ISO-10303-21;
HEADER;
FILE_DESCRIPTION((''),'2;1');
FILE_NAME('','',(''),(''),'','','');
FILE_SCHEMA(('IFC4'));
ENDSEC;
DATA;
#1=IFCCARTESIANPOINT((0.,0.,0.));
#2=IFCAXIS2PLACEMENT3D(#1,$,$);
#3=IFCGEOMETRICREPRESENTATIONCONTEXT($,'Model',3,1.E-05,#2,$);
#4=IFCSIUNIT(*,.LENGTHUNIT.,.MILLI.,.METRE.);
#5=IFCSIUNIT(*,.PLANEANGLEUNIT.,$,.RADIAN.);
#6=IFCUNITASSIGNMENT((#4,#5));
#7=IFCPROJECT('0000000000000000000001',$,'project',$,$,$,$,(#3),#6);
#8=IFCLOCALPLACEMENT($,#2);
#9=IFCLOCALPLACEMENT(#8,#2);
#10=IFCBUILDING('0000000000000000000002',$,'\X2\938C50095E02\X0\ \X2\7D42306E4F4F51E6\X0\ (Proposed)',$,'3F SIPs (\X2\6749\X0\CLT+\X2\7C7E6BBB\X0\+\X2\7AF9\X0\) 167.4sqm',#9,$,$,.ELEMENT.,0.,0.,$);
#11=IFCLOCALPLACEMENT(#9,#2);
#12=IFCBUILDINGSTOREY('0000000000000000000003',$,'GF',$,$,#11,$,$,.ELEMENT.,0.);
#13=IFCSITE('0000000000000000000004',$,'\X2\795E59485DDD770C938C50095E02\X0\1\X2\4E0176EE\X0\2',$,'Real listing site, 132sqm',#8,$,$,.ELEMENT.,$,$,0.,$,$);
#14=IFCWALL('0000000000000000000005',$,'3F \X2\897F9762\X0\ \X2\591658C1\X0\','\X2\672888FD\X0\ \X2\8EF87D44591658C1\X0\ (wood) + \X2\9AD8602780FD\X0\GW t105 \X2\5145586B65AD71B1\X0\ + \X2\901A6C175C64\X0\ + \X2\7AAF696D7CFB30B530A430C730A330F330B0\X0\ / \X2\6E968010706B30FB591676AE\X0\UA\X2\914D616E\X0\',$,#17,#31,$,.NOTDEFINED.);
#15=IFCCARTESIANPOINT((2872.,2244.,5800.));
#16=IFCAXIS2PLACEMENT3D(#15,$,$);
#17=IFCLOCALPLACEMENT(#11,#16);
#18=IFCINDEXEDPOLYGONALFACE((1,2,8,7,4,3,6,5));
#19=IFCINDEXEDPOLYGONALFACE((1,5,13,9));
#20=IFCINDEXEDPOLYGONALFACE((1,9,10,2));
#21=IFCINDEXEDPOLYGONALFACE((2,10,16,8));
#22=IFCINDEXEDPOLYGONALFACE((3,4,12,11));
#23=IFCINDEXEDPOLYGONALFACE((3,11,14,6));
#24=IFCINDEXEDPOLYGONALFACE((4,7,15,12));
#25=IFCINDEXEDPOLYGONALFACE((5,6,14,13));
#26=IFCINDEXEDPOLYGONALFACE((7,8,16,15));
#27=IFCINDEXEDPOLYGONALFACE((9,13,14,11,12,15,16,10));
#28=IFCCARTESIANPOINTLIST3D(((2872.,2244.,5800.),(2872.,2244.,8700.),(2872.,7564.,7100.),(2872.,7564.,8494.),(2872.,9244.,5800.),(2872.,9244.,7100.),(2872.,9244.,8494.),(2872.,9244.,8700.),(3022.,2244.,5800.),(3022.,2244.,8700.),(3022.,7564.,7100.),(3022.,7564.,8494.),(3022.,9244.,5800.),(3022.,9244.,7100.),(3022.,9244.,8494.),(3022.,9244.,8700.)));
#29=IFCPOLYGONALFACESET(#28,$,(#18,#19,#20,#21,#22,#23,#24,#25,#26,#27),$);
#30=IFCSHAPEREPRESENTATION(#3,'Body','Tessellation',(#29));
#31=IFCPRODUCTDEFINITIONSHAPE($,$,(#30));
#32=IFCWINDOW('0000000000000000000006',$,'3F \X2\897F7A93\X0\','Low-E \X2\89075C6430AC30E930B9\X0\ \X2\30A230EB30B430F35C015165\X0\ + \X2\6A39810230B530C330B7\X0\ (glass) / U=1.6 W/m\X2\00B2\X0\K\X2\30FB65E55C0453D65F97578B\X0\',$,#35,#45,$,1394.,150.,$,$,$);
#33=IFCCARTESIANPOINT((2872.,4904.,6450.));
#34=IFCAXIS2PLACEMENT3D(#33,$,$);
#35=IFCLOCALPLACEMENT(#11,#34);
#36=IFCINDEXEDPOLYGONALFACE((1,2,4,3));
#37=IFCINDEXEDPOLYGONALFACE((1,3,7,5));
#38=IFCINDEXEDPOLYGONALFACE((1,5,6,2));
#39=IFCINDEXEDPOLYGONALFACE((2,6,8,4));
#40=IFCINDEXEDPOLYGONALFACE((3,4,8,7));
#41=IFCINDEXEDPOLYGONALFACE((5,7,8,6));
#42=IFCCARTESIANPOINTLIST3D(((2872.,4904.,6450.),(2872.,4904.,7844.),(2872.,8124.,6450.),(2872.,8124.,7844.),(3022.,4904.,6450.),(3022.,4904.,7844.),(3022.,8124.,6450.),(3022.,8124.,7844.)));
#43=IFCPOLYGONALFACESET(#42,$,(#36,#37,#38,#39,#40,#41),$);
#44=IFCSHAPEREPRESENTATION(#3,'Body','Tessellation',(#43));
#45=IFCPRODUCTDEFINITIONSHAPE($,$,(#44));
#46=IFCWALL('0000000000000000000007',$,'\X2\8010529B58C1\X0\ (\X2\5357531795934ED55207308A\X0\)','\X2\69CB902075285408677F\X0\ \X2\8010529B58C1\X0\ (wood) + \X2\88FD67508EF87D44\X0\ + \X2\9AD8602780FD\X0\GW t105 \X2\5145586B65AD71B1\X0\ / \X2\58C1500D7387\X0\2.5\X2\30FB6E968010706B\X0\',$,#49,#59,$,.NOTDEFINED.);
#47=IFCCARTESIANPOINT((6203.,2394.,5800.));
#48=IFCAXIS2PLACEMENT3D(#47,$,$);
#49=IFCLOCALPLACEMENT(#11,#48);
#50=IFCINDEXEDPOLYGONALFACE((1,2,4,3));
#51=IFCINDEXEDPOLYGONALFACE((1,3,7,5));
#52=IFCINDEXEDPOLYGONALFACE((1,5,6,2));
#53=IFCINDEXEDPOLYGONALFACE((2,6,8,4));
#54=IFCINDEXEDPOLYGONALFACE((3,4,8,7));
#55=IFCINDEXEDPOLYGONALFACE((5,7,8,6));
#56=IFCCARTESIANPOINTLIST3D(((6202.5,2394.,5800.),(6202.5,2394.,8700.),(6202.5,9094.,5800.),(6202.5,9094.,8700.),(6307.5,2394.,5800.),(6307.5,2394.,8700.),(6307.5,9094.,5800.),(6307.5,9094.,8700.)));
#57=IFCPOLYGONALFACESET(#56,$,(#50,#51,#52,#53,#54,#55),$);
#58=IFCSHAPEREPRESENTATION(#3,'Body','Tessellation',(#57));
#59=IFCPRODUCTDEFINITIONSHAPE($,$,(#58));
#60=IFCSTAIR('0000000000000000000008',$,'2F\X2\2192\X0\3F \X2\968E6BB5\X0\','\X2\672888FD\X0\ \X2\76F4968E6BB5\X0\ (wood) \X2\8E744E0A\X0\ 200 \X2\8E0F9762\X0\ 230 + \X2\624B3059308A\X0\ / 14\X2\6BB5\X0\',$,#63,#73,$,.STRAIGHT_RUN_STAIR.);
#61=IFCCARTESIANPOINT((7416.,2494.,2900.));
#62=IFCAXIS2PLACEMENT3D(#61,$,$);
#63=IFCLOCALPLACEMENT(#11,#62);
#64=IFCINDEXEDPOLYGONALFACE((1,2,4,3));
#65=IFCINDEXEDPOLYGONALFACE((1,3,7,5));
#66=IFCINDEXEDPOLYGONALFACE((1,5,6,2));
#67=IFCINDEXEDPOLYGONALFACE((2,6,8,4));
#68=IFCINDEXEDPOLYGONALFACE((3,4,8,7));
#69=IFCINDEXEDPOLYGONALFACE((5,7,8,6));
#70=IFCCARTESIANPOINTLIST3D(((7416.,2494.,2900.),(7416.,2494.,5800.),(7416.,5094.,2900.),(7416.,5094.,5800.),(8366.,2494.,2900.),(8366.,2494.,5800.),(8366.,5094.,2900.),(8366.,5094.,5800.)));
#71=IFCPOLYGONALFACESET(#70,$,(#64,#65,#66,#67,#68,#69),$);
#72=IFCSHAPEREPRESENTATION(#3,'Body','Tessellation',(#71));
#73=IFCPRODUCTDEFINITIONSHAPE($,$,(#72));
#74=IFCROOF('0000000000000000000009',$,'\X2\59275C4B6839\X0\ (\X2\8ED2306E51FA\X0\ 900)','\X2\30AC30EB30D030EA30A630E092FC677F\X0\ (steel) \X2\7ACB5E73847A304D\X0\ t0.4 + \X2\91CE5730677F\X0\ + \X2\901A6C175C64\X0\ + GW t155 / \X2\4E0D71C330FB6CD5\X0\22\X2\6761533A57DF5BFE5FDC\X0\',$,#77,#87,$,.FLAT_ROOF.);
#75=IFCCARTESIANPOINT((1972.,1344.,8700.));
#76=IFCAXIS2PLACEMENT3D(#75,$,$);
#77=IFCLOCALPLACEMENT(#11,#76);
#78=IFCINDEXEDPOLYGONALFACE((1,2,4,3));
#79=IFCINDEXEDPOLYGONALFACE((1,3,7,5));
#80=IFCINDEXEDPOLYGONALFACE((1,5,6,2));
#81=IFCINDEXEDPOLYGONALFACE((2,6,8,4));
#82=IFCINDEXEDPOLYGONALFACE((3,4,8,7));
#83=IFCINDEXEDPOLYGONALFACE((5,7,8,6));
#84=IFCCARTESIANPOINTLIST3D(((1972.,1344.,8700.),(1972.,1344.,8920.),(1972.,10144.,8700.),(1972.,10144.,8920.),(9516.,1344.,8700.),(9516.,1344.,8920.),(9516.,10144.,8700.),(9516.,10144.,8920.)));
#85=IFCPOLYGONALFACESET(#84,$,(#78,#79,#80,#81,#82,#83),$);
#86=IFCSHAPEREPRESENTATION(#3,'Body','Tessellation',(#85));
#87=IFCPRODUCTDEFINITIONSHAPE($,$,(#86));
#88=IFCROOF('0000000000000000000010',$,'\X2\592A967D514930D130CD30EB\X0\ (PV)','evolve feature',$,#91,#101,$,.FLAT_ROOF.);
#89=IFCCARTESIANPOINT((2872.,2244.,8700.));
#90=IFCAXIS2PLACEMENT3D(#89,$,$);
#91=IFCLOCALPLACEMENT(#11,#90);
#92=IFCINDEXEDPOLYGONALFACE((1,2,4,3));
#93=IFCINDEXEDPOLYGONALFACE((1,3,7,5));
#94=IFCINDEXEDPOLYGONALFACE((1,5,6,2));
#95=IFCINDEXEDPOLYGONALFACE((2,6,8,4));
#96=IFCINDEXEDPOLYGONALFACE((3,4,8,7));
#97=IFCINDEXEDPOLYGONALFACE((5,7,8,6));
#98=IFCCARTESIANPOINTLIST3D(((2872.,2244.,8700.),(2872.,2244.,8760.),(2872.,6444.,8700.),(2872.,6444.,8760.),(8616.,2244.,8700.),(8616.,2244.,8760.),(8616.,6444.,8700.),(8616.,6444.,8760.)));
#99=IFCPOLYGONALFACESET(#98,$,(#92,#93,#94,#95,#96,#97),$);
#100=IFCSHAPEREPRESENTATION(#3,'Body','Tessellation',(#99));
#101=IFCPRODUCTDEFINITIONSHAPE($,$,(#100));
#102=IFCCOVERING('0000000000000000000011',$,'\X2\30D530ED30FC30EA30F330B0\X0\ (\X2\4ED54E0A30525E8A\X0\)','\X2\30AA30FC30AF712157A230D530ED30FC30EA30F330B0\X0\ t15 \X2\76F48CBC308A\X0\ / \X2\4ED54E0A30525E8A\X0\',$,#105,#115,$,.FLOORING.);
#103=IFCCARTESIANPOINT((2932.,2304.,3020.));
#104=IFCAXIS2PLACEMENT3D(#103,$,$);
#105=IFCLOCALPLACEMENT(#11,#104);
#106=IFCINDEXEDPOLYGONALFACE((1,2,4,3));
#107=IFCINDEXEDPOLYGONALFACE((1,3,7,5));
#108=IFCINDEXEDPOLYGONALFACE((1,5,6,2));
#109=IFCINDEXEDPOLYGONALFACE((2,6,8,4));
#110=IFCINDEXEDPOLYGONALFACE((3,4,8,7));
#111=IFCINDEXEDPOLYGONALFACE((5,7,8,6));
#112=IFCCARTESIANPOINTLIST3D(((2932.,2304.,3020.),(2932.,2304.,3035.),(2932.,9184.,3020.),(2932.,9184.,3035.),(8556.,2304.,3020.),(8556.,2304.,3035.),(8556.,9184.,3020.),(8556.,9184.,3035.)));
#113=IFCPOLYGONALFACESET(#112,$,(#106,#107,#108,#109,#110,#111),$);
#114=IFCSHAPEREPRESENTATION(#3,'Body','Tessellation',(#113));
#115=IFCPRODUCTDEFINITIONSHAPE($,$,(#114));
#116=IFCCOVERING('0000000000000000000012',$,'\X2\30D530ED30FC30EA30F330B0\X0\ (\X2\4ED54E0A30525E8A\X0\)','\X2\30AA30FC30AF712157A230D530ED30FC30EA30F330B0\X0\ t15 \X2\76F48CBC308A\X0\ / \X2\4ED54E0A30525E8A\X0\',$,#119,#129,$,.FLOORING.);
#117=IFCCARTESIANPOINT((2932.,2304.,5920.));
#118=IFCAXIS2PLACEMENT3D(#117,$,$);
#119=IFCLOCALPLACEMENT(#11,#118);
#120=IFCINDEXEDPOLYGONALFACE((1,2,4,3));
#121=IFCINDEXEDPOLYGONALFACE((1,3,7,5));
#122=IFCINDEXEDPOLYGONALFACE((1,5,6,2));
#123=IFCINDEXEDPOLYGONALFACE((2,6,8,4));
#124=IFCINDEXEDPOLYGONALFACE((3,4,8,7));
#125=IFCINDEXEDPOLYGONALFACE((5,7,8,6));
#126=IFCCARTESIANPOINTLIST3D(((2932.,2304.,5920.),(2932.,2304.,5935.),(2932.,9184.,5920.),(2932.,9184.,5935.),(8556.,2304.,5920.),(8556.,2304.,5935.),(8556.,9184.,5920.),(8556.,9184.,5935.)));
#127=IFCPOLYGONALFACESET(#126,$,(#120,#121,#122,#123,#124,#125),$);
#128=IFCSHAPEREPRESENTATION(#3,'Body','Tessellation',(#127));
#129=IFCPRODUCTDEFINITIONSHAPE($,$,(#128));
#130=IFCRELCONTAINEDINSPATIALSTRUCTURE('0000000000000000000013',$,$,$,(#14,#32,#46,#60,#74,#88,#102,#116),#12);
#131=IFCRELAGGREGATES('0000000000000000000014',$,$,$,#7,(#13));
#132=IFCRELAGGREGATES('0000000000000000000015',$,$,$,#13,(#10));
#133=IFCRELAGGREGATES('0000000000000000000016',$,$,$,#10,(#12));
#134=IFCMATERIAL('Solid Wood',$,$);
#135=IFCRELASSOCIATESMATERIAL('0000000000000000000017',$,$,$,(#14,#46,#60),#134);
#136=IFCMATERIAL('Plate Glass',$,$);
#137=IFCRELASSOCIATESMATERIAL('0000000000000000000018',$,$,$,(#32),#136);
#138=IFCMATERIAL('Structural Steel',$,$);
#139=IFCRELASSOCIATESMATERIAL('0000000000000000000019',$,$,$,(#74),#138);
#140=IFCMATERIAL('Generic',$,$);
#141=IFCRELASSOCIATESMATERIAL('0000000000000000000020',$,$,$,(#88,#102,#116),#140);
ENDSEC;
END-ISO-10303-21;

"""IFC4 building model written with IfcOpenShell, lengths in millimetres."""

from ifc_helpers import new_model, si_unit, frame, frame_2d, origin, place, context, project, spatial, rectangle, extrude, material, element, fill, save


model = new_model("IFC4")

# Units and contexts
model_context = context("Model", 3, precision=1e-05, world=origin())
ifc_project = project(units=[si_unit("LENGTHUNIT", "METRE", prefix="MILLI"), si_unit("PLANEANGLEUNIT", "RADIAN")], contexts=[model_context])

# Site, building, storey
site_placement = place(None, origin())
site = spatial("IfcSite", under=ifc_project, at=site_placement, Name="神奈川県鎌倉市1丁目2", ObjectType="Real listing site, 132sqm", CompositionType="ELEMENT", RefElevation=0.0)
building_placement = place(site_placement, origin())
building = spatial("IfcBuilding", under=site, at=building_placement, Name="鎌倉市 終の住処 (Proposed)", ObjectType="3F SIPs (杉CLT+籾殻+竹) 167.4sqm", CompositionType="ELEMENT", ElevationOfRefHeight=0.0, ElevationOfTerrain=0.0)
storey_placement = place(building_placement, origin())
storey = spatial("IfcBuildingStorey", under=building, at=storey_placement, Name="GF", CompositionType="ELEMENT", Elevation=0.0)

# Shared definitions
ifc_material_1 = material(Name="Solid Wood")

# Shared definitions
ifc_material_2 = material(Name="Plate Glass")

# Shared definitions
ifc_material_3 = material(Name="Generic")

# Wall, opening, window
wall_1_placement = place(storey_placement, frame((2872.0, 2244.0, 5800.0)))
wall_1 = element("IfcWall", 1, at=wall_1_placement, inside=storey, material=ifc_material_1, Name="3F 西面 外壁", Description="木製 軸組外壁 (wood) + 高性能GW t105 充填断熱 + 通気層 + 窯業系サイディング / 準耐火・外皮UA配慮", PredefinedType="NOTDEFINED", context=model_context, shape_type="SweptSolid", body=[
    extrude(rectangle(XDim=150.0, YDim=7000.0, at=frame_2d((75.0, 3500.0))), frame((2872.0, 2244.0, 5800.0)), (0.0, 0.0, 1.0), 2900.0),
])
opening_1_placement = place(storey_placement, frame((2872.0, 4904.0, 6450.0)))
opening_1 = element("IfcOpeningElement", 2, at=opening_1_placement, cuts=wall_1, PredefinedType="NOTDEFINED", context=model_context, shape_type="SweptSolid", body=[
    extrude(rectangle(XDim=150.0, YDim=3220.0, at=frame_2d((75.0, 1610.0))), frame((2872.0, 4904.0, 6450.0)), (0.0, 0.0, 1.0), 1394.0),
])
window_1_placement = place(storey_placement, frame((2872.0, 4904.0, 6450.0)))
window_1 = element("IfcWindow", 3, at=window_1_placement, inside=storey, material=ifc_material_2, Name="3F 西窓", Description="Low-E 複層ガラス アルゴン封入 + 樹脂サッシ (glass) / U=1.6 W/m²K・日射取得型", OverallHeight=1394.0, OverallWidth=150.0, context=model_context, shape_type="SweptSolid", body=[
    extrude(rectangle(XDim=150.0, YDim=3220.0, at=frame_2d((75.0, 1610.0))), frame((2872.0, 4904.0, 6450.0)), (0.0, 0.0, 1.0), 1394.0),
])
fill(opening_1, window_1)

# Wall
wall_2_placement = place(storey_placement, frame((6203.0, 2394.0, 5800.0)))
element("IfcWall", 4, at=wall_2_placement, inside=storey, material=ifc_material_1, Name="耐力壁 (南北間仕切り)", Description="構造用合板 耐力壁 (wood) + 製材軸組 + 高性能GW t105 充填断熱 / 壁倍率2.5・準耐火", PredefinedType="NOTDEFINED", context=model_context, shape_type="SweptSolid", body=[
    extrude(rectangle(XDim=105.0, YDim=6700.0, at=frame_2d((52.0, 3350.0))), frame((6203.0, 2394.0, 5800.0)), (0.0, 0.0, 1.0), 2900.0),
])

# Stair
stair_placement = place(storey_placement, frame((7416.0, 2494.0, 2900.0)))
element("IfcStair", 5, at=stair_placement, inside=storey, material=ifc_material_1, Name="2F→3F 階段", Description="木製 直階段 (wood) 蹴上 200 踏面 230 + 手すり / 14段", PredefinedType="STRAIGHT_RUN_STAIR", context=model_context, shape_type="SweptSolid", body=[
    extrude(rectangle(XDim=950.0, YDim=2600.0, at=frame_2d((475.0, 1300.0))), frame((7416.0, 2494.0, 2900.0)), (0.0, 0.0, 1.0), 2900.0),
])

# Roofs
ifc_material_4 = material(Name="Structural Steel")
roof_1_placement = place(storey_placement, frame((1972.0, 1344.0, 8700.0)))
element("IfcRoof", 6, at=roof_1_placement, inside=storey, material=ifc_material_4, Name="大屋根 (軒の出 900)", Description="ガルバリウム鋼板 (steel) 立平葺き t0.4 + 野地板 + 通気層 + GW t155 / 不燃・法22条区域対応", PredefinedType="FLAT_ROOF", context=model_context, shape_type="SweptSolid", body=[
    extrude(rectangle(XDim=7544.0, YDim=8800.0, at=frame_2d((3772.0, 4400.0))), frame((1972.0, 1344.0, 8700.0)), (0.0, 0.0, 1.0), 220.0),
])
roof_2_placement = place(storey_placement, frame((2872.0, 2244.0, 8700.0)))
element("IfcRoof", 7, at=roof_2_placement, inside=storey, material=ifc_material_3, Name="太陽光パネル (PV)", Description="evolve feature", PredefinedType="FLAT_ROOF", context=model_context, shape_type="SweptSolid", body=[
    extrude(rectangle(XDim=5744.0, YDim=4200.0, at=frame_2d((2872.0, 2100.0))), frame((2872.0, 2244.0, 8700.0)), (0.0, 0.0, 1.0), 60.0),
])

# Coverings
covering_1_placement = place(storey_placement, frame((2932.0, 2304.0, 3020.0)))
element("IfcCovering", 8, at=covering_1_placement, inside=storey, material=ifc_material_3, Name="フローリング (仕上げ床)", Description="オーク無垢フローリング t15 直貼り / 仕上げ床", PredefinedType="FLOORING", context=model_context, shape_type="SweptSolid", body=[
    extrude(rectangle(XDim=5624.0, YDim=6880.0, at=frame_2d((2812.0, 3440.0))), frame((2932.0, 2304.0, 3020.0)), (0.0, 0.0, 1.0), 15.0),
])
covering_2_placement = place(storey_placement, frame((2932.0, 2304.0, 5920.0)))
element("IfcCovering", 9, at=covering_2_placement, inside=storey, material=ifc_material_3, Name="フローリング (仕上げ床)", Description="オーク無垢フローリング t15 直貼り / 仕上げ床", PredefinedType="FLOORING", context=model_context, shape_type="SweptSolid", body=[
    extrude(rectangle(XDim=5624.0, YDim=6880.0, at=frame_2d((2812.0, 3440.0))), frame((2932.0, 2304.0, 5920.0)), (0.0, 0.0, 1.0), 15.0),
])

save(model, "model.ifc")
